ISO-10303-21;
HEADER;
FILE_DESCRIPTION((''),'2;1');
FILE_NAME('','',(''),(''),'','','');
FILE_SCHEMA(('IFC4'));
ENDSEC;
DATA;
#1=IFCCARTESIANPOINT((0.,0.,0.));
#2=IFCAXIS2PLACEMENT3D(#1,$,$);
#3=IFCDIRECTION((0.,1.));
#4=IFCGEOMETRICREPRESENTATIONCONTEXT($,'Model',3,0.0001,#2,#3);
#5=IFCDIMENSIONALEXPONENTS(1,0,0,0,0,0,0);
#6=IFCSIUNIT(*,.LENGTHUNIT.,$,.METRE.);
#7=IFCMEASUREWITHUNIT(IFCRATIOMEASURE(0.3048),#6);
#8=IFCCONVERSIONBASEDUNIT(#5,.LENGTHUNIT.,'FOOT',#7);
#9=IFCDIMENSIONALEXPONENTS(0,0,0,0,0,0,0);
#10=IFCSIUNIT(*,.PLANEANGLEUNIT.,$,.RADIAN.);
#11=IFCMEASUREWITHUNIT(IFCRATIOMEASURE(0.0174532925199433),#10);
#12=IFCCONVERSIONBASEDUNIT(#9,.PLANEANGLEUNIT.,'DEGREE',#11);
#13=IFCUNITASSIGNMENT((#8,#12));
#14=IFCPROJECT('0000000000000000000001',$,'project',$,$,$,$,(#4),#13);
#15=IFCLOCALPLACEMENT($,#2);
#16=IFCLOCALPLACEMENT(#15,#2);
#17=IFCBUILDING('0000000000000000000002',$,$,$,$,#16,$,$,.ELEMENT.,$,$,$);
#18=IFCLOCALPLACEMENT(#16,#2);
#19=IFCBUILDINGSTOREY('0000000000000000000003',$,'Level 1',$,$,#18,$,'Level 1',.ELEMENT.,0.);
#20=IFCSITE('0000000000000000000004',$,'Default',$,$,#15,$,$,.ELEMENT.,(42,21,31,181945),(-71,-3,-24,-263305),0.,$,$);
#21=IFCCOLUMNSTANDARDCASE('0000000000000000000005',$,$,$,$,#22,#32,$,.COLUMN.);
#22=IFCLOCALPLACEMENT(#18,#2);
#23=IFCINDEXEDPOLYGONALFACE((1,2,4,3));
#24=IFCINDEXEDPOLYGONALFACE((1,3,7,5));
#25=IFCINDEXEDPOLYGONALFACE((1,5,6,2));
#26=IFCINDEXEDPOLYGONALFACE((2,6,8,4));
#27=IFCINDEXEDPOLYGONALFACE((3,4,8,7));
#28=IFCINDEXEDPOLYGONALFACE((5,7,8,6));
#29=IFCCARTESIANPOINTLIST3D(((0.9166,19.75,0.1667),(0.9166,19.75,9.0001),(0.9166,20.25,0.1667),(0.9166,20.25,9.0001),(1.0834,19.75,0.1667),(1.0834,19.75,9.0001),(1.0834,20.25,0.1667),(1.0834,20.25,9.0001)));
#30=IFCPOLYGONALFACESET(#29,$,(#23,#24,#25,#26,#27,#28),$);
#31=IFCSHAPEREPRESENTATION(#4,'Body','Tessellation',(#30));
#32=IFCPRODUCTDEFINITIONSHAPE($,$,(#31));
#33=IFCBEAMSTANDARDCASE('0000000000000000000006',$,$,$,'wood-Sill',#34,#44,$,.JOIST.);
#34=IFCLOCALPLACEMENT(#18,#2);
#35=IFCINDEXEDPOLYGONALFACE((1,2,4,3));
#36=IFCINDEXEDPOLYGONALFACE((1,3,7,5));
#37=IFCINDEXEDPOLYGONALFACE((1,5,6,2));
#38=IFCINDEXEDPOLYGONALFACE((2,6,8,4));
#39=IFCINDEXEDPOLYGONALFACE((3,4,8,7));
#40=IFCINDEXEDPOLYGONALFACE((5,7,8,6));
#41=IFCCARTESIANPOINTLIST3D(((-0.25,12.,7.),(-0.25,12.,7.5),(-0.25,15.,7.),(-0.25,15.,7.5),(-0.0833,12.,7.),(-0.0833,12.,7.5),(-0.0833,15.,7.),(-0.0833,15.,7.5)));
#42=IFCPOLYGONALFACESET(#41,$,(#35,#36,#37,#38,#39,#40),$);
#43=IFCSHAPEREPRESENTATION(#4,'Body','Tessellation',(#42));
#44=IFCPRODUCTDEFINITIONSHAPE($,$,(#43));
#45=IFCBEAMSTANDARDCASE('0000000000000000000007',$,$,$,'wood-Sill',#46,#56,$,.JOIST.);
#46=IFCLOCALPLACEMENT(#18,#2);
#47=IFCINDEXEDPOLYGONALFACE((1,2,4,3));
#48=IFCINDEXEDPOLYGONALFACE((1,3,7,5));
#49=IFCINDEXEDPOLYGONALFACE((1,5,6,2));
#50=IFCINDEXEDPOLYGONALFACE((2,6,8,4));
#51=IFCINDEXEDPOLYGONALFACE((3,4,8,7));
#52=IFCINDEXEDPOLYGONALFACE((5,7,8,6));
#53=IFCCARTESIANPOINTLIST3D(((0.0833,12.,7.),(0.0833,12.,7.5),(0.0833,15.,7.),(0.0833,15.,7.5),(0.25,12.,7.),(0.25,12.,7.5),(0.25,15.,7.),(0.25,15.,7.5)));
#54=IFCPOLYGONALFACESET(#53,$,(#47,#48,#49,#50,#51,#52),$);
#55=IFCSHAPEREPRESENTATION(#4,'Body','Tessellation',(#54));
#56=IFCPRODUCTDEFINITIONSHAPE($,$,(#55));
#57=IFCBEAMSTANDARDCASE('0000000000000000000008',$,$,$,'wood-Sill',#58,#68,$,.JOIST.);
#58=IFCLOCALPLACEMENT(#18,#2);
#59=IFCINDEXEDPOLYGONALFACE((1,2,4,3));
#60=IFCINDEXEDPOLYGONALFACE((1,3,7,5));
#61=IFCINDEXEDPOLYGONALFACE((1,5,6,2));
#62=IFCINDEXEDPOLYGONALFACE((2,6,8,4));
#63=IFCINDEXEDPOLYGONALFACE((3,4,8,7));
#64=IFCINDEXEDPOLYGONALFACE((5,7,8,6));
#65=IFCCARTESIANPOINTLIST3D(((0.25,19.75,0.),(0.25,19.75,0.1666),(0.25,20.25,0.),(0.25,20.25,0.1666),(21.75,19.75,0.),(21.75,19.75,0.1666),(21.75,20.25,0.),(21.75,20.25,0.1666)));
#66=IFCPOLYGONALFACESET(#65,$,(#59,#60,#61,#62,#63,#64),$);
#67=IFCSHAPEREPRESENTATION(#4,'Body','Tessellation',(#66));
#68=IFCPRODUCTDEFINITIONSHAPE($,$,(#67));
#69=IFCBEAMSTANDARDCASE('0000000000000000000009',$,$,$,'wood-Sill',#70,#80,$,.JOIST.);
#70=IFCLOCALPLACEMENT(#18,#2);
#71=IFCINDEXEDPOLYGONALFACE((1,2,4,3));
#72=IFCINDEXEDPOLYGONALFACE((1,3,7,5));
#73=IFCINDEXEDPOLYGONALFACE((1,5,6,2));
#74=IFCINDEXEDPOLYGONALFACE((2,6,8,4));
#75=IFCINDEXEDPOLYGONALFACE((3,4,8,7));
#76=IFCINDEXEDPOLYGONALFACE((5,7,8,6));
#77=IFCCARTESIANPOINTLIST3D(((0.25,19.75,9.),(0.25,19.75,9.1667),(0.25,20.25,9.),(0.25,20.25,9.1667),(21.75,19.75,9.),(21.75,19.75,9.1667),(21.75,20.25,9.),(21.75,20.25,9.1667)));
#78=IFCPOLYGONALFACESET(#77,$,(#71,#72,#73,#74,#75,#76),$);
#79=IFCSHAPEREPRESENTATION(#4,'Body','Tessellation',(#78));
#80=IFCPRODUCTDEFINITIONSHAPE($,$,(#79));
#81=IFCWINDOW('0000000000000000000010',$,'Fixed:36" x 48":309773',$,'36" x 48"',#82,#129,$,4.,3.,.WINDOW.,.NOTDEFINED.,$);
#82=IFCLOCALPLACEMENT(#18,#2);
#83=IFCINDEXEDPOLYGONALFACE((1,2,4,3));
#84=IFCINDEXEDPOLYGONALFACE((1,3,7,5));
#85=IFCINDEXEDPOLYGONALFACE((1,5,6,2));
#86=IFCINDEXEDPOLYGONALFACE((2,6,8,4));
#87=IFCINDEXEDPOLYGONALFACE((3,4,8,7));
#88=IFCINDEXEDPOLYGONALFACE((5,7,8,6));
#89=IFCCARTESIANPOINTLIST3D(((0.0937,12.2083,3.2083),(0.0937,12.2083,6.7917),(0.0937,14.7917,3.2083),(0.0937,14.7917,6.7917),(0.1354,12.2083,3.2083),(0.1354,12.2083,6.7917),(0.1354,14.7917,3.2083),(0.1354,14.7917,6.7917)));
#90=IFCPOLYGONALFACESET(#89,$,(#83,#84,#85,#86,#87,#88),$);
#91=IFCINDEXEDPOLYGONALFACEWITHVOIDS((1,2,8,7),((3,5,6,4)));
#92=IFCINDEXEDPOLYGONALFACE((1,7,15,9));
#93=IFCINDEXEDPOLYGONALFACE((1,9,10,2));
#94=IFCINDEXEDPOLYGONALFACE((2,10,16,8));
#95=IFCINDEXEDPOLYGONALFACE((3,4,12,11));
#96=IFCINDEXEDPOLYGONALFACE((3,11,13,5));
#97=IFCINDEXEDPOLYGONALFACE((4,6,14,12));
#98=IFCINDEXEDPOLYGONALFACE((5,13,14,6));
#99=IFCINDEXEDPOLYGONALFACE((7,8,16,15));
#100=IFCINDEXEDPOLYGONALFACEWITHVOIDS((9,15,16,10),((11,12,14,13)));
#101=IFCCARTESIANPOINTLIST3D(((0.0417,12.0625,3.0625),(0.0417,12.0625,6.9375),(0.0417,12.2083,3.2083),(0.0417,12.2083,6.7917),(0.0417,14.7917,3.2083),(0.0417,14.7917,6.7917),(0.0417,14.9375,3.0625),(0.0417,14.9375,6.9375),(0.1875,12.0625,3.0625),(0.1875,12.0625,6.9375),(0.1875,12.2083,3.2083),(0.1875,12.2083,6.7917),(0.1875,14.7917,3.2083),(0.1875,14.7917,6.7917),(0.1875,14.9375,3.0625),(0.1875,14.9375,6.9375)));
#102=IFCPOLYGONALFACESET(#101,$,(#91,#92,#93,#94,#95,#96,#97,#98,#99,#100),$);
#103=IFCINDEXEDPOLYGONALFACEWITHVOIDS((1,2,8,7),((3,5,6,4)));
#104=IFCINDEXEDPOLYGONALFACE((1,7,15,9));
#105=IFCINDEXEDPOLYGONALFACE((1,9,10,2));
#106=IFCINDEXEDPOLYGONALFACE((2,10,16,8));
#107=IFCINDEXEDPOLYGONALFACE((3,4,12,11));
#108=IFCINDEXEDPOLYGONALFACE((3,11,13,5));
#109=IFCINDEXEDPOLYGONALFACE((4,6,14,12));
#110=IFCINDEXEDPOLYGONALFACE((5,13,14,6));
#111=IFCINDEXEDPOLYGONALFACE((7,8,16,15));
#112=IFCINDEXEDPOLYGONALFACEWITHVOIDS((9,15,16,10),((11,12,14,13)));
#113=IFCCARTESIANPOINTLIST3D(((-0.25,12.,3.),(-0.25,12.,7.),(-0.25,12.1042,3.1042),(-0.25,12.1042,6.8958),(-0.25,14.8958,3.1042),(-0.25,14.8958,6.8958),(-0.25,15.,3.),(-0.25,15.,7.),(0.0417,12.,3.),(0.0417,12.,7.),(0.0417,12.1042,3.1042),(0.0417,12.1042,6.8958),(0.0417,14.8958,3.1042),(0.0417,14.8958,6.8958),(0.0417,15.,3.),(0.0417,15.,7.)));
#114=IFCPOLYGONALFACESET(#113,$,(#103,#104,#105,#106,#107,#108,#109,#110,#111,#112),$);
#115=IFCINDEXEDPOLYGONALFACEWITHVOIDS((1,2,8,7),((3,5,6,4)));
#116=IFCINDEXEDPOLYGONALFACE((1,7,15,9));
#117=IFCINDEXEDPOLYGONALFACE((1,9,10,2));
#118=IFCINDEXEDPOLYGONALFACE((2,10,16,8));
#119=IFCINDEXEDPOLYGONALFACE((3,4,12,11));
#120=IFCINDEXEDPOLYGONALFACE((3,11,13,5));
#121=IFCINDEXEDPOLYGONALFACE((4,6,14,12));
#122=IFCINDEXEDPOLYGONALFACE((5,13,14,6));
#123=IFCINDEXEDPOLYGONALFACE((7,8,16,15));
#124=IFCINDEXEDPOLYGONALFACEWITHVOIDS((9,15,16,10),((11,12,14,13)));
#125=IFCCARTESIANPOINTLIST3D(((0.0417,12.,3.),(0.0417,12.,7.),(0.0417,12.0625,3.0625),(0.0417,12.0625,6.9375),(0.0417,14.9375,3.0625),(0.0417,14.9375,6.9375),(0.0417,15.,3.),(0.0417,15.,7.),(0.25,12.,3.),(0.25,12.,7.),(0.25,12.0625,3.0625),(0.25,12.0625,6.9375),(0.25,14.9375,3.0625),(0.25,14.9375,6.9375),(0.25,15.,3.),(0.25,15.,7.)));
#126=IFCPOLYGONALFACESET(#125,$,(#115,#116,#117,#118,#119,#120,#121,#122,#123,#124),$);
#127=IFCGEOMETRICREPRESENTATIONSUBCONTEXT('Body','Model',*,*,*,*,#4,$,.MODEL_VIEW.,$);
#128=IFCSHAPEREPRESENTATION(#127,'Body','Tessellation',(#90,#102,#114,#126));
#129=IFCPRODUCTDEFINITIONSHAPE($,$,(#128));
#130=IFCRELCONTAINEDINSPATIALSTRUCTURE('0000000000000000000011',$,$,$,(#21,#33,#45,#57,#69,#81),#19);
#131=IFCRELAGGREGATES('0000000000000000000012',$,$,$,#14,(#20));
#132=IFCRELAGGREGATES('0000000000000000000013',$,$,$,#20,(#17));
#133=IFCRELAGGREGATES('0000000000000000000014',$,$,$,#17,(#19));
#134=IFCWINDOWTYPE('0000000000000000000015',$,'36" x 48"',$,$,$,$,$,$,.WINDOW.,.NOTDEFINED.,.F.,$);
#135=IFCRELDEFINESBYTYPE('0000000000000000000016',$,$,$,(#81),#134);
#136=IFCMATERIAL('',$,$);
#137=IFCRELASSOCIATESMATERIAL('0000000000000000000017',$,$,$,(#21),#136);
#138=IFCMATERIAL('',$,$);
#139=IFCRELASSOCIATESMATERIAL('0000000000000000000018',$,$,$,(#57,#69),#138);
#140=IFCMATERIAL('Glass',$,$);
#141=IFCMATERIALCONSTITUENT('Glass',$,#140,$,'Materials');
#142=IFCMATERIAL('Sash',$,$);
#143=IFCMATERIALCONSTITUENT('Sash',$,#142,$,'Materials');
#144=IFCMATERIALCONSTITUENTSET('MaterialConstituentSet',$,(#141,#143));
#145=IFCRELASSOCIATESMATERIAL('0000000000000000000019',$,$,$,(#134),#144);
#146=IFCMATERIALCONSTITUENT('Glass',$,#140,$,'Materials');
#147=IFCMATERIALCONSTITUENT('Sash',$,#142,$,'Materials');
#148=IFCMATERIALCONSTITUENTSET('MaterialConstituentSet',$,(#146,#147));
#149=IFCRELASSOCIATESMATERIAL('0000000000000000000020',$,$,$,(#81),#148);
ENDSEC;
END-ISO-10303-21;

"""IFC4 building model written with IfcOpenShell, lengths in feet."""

from ifc_helpers import new_model, entity, si_unit, converted_unit, direction, frame, frame_2d, origin, origin_with_axes, place, context, subcontext, project, spatial, polyline, rectangle, outline, extrude, source, transform, mapped, material, constituent, constituent_set, type_object, type_shapes, element, save


model = new_model("IFC4")

# Units and contexts
model_context = context("Model", 3, precision=0.0001, world=origin(), true_north=direction((0.0, 1.0)))
body_context = subcontext(model_context, "Body", "Model", "MODEL_VIEW")
ifc_project = project(units=[converted_unit("LENGTHUNIT", "FOOT", entity("IfcRatioMeasure", 0.3048), si_unit("LENGTHUNIT", "METRE"), dimensions=[1, 0, 0, 0, 0, 0, 0]), converted_unit("PLANEANGLEUNIT", "DEGREE", entity("IfcRatioMeasure", 0.0174532925199433), si_unit("PLANEANGLEUNIT", "RADIAN"), dimensions=[0, 0, 0, 0, 0, 0, 0])], contexts=[model_context])

# Site, building, storey
site_placement = place(None, origin())
site = spatial("IfcSite", under=ifc_project, at=site_placement, Name="Default", CompositionType="ELEMENT", RefLatitude=(42, 21, 31, 181945), RefLongitude=(-71, -3, -24, -263305), RefElevation=0.0)
building_placement = place(site_placement, origin())
building = spatial("IfcBuilding", under=site, at=building_placement, CompositionType="ELEMENT")
storey_placement = place(building_placement, origin())
storey = spatial("IfcBuildingStorey", under=building, at=storey_placement, Name="Level 1", LongName="Level 1", CompositionType="ELEMENT", Elevation=0.0)

# Column
placement_1 = place(storey_placement, frame((0.0, -0.25, 0.0), z_axis=(0.0, 0.0, 1.0), x_axis=(0.0, 1.0, 0.0)))
ifc_material_1 = material(Name="")
placement_2 = place(storey_placement, frame((0.25, 20.0, 0.0)))
for number, where, z_axis, x_axis in (
    (1, (0.75, 0.0, 0.1667), (0.0, 0.0, 1.0), (1.0, 0.0, 0.0)),
):
    element("IfcColumnStandardCase", number, at=place(placement_2, frame(where, z_axis=z_axis, x_axis=x_axis)), inside=storey, material=ifc_material_1, PredefinedType="COLUMN", context=model_context, shape_type="SweptSolid", body=[
        extrude(rectangle(XDim=0.1667, YDim=0.5), origin(), (0.0, 0.0, 1.0), 8.8334),
    ])

# Beams
for number, where, z_axis, x_axis in (
    (2, (12.25, 0.1667, 7.25), (1.0, 0.0, 0.0), (0.0, 0.0, 1.0)),
    (3, (12.25, -0.1667, 7.25), (1.0, 0.0, 0.0), (0.0, 0.0, 1.0)),
):
    element("IfcBeamStandardCase", number, at=place(placement_1, frame(where, z_axis=z_axis, x_axis=x_axis)), inside=storey, ObjectType="wood-Sill", PredefinedType="JOIST", context=model_context, shape_type="SweptSolid", body=[
        extrude(rectangle(XDim=0.5, YDim=0.1667), origin_with_axes(), (0.0, 0.0, 1.0), 3.0),
    ])
ifc_material_2 = material(Name="")
for number, where, z_axis, x_axis in (
    (4, (0.0, 0.0, 0.0833), (1.0, 0.0, 0.0), (0.0, 0.0, 1.0)),
    (5, (0.0, 0.0, 9.0834), (1.0, 0.0, 0.0), (0.0, 0.0, 1.0)),
):
    element("IfcBeamStandardCase", number, at=place(placement_2, frame(where, z_axis=z_axis, x_axis=x_axis)), inside=storey, material=ifc_material_2, ObjectType="wood-Sill", PredefinedType="JOIST", context=model_context, shape_type="SweptSolid", body=[
        extrude(rectangle(XDim=0.1667, YDim=0.5), origin_with_axes(), (0.0, 0.0, 1.0), 21.5),
    ])

# Window
ifc_material_3 = material(Name="Glass")
ifc_constituent_1 = constituent(ifc_material_3, Name="Glass", Category="Materials")
ifc_material_4 = material(Name="Sash")
ifc_constituent_2 = constituent(ifc_material_4, Name="Sash", Category="Materials")
ifc_constituent_set_1 = constituent_set(constituents=[ifc_constituent_1, ifc_constituent_2], Name="MaterialConstituentSet")
ifc_constituent_3 = constituent(ifc_material_3, Name="Glass", Category="Materials")
ifc_constituent_4 = constituent(ifc_material_4, Name="Sash", Category="Materials")
ifc_constituent_set_2 = constituent_set(constituents=[ifc_constituent_3, ifc_constituent_4], Name="MaterialConstituentSet")
window_type = type_object("IfcWindowType", Name="36\" x 48\"", ParameterTakesPrecedence=False, PartitioningType="NOTDEFINED", PredefinedType="WINDOW", material=ifc_constituent_set_2)
shared_shape = source(origin(), body_context, "Body", "SweptSolid", [
    extrude(rectangle(XDim=0.0417, YDim=2.5833, at=frame_2d((0.0, 0.0), x_axis=(1.0, 0.0))), frame((1.5, 0.3646, 0.2083), z_axis=(0.0, 0.0, 1.0), x_axis=(0.0, 1.0, 0.0)), (0.0, 0.0, 1.0), 3.5833),
    extrude(outline(polyline([(-1.4375, -1.9375), (1.4375, -1.9375), (1.4375, 1.9375), (-1.4375, 1.9375), (-1.4375, -1.9375)]), holes=[polyline([(-1.2917, -1.7917), (-1.2917, 1.7917), (1.2917, 1.7917), (1.2917, -1.7917), (-1.2917, -1.7917)])]), frame((1.5, 0.2917, 2.0), z_axis=(0.0, 1.0, 0.0), x_axis=(1.0, 0.0, 0.0)), (0.0, 0.0, 1.0), 0.1458),
    extrude(outline(polyline([(-1.5, -2.0), (1.5, -2.0), (1.5, 2.0), (-1.5, 2.0), (-1.5, -2.0)]), holes=[polyline([(-1.3958, -1.8958), (-1.3958, 1.8958), (1.3958, 1.8958), (1.3958, -1.8958), (-1.3958, -1.8958)])]), frame((1.5, 0.0, 2.0), z_axis=(0.0, 1.0, 0.0), x_axis=(1.0, 0.0, 0.0)), (0.0, 0.0, 1.0), 0.2917),
    extrude(outline(polyline([(-2.0, -1.5), (2.0, -1.5), (2.0, 1.5), (-2.0, 1.5), (-2.0, -1.5)]), holes=[polyline([(-1.9375, -1.4375), (-1.9375, 1.4375), (1.9375, 1.4375), (1.9375, -1.4375), (-1.9375, -1.4375)])]), frame((1.5, 0.2917, 2.0), z_axis=(0.0, 1.0, 0.0), x_axis=(0.0, 0.0, -1.0)), (0.0, 0.0, 1.0), 0.2083),
])
type_shapes(window_type, [shared_shape])
placement_3 = place(placement_1, frame((15.25, 0.25, 3.0)))
window_placement = place(placement_3, frame((0.0, 0.0, 0.0), z_axis=(0.0, 0.0, 1.0), x_axis=(-1.0, 0.0, 0.0)))
element("IfcWindow", 6, at=window_placement, inside=storey, type_object=window_type, material=ifc_constituent_set_1, Name="Fixed:36\" x 48\":309773", ObjectType="36\" x 48\"", OverallHeight=4.0, OverallWidth=3.0, PartitioningType="NOTDEFINED", PredefinedType="WINDOW", context=body_context, shape_type="MappedRepresentation", body=[
    mapped(shared_shape, transform((0.0, 0.0, 0.0), scale=1.0)),
])

save(model, "model.ifc")
